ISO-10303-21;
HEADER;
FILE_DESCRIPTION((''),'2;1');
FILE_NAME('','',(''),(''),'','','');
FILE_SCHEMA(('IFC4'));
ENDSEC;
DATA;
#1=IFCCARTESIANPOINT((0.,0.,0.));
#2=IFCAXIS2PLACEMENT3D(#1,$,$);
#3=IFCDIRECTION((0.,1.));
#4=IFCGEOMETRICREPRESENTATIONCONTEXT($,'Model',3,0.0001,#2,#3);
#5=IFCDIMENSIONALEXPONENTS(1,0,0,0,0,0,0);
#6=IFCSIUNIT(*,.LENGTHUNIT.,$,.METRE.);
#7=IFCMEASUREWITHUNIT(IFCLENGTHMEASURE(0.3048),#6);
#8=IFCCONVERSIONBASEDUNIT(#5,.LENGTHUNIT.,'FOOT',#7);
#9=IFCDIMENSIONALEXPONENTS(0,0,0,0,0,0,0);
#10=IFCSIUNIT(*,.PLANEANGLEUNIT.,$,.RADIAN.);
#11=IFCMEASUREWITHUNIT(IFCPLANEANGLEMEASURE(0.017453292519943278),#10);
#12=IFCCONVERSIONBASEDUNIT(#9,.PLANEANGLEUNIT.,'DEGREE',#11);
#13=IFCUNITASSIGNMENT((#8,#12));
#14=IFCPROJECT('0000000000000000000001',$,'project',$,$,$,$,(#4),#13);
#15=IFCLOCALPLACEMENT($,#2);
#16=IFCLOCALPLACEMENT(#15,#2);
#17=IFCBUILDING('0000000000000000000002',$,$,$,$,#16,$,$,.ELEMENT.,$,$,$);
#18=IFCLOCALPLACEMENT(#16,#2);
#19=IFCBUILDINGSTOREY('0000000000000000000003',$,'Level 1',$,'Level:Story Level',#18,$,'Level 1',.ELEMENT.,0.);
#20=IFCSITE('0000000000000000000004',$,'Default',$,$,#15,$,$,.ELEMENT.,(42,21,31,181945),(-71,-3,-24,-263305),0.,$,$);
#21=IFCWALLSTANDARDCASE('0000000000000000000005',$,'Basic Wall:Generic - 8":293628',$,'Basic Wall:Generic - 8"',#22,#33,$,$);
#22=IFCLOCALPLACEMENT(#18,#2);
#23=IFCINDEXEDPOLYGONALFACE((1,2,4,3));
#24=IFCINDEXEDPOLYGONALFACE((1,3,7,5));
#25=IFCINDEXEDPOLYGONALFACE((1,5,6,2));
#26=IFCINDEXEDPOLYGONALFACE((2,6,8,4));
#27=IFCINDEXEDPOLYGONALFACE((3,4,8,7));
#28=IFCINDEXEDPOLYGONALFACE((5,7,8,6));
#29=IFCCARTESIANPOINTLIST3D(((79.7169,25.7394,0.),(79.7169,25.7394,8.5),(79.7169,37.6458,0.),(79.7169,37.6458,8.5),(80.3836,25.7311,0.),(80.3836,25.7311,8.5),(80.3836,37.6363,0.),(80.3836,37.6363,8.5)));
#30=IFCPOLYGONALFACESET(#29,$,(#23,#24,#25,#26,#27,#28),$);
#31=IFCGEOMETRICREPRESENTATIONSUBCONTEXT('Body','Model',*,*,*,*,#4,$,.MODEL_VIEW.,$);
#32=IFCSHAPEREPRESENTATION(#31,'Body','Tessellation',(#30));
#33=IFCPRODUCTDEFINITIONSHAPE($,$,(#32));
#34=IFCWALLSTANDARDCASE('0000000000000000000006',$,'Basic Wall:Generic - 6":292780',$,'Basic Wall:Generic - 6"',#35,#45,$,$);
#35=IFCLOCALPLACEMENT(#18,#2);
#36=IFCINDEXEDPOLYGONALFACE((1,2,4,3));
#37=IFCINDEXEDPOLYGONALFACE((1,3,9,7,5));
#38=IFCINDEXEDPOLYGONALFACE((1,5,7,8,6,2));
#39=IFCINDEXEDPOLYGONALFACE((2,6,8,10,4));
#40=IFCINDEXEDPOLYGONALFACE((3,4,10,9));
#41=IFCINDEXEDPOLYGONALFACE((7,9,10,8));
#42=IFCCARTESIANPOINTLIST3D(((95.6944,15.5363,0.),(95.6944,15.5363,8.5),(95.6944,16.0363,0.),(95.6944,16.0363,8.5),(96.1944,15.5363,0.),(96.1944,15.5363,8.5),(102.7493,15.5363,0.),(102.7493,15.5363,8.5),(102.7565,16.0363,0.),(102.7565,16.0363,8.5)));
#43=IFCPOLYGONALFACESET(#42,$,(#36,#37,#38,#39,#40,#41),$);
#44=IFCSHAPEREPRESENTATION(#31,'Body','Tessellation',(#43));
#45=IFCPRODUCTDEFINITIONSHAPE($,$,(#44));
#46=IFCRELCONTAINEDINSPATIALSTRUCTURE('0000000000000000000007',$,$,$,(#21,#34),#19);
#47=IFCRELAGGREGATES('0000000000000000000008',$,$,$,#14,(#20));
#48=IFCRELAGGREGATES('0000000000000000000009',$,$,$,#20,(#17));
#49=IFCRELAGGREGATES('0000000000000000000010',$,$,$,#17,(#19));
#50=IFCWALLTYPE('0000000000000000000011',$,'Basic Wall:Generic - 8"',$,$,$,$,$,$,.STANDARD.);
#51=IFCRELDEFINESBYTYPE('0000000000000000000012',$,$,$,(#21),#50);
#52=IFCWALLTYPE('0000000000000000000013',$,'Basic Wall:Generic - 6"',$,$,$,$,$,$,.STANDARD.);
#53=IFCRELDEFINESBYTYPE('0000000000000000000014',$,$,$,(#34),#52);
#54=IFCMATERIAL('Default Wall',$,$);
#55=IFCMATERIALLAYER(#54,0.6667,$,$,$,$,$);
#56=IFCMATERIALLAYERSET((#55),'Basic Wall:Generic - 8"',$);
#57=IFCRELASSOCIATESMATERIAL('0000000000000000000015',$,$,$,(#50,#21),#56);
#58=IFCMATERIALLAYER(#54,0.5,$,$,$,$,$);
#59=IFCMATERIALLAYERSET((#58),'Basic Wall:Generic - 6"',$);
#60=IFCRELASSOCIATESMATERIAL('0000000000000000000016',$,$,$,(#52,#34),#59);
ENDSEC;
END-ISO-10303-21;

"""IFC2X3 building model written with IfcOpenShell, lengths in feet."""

from ifc_helpers import new_model, entity, si_unit, converted_unit, direction, frame, origin, place, context, subcontext, project, spatial, polyline, outline, extrude, material, layer, layer_set, layer_usage, type_object, element, save


model = new_model("IFC2X3")

# Units and contexts
model_context = context("Model", 3, precision=0.0001, world=origin(), true_north=direction((0.0, 1.0)))
body_context = subcontext(model_context, "Body", "Model", "MODEL_VIEW")
ifc_project = project(units=[converted_unit("LENGTHUNIT", "FOOT", entity("IfcLengthMeasure", 0.3048), si_unit("LENGTHUNIT", "METRE"), dimensions=[1, 0, 0, 0, 0, 0, 0]), converted_unit("PLANEANGLEUNIT", "DEGREE", entity("IfcPlaneAngleMeasure", 0.017453292519943278), si_unit("PLANEANGLEUNIT", "RADIAN"), dimensions=[0, 0, 0, 0, 0, 0, 0])], contexts=[model_context])

# Site, building, storey
site_placement = place(None, origin())
site = spatial("IfcSite", under=ifc_project, at=site_placement, Name="Default", CompositionType="ELEMENT", RefLatitude=(42, 21, 31, 181945), RefLongitude=(-71, -3, -24, -263305), RefElevation=0.0)
building_placement = place(site_placement, origin())
building = spatial("IfcBuilding", under=site, at=building_placement, CompositionType="ELEMENT")
storey_placement = place(building_placement, origin())
storey = spatial("IfcBuildingStorey", under=building, at=storey_placement, Name="Level 1", ObjectType="Level:Story Level", LongName="Level 1", CompositionType="ELEMENT", Elevation=0.0)

# Walls
ifc_material = material(Name="Default Wall")
ifc_layer_1 = layer(ifc_material, 0.6667)
ifc_layer_set_1 = layer_set([ifc_layer_1], Name="Basic Wall:Generic - 8\"")
ifc_layer_usage_1 = layer_usage(ifc_layer_set_1, "AXIS2", "NEGATIVE", 0.3333)
wall_type_1 = type_object("IfcWallType", Name="Basic Wall:Generic - 8\"", PredefinedType="STANDARD", material=ifc_layer_set_1)
wall_1_placement = place(storey_placement, frame((80.0502, 37.6458, 0.0), z_axis=(0.0, 0.0, 1.0), x_axis=(0.0, -1.0, 0.0)))
element("IfcWallStandardCase", 1, at=wall_1_placement, inside=storey, type_object=wall_type_1, material=ifc_layer_usage_1, Name="Basic Wall:Generic - 8\":293628", ObjectType="Basic Wall:Generic - 8\"", context=body_context, shape_type="SweptSolid", body=[
    extrude(outline(polyline([(11.9065, -0.3333), (11.9147, 0.3333), (0.0095, 0.3333), (0.0, -0.3333), (11.9065, -0.3333)])), origin(), (0.0, 0.0, 1.0), 8.5),
])
ifc_layer_2 = layer(ifc_material, 0.5)
ifc_layer_set_2 = layer_set([ifc_layer_2], Name="Basic Wall:Generic - 6\"")
ifc_layer_usage_2 = layer_usage(ifc_layer_set_2, "AXIS2", "NEGATIVE", 0.25)
wall_type_2 = type_object("IfcWallType", Name="Basic Wall:Generic - 6\"", PredefinedType="STANDARD", material=ifc_layer_set_2)
wall_2_placement = place(storey_placement, frame((102.7565, 15.7863, 0.0), z_axis=(0.0, 0.0, 1.0), x_axis=(-1.0, 0.0, 0.0)))
element("IfcWallStandardCase", 2, at=wall_2_placement, inside=storey, type_object=wall_type_2, material=ifc_layer_usage_2, Name="Basic Wall:Generic - 6\":292780", ObjectType="Basic Wall:Generic - 6\"", context=body_context, shape_type="SweptSolid", body=[
    extrude(outline(polyline([(7.0621, -0.25), (7.0621, 0.25), (6.5621, 0.25), (0.0071, 0.25), (0.0, -0.25), (7.0621, -0.25)])), origin(), (0.0, 0.0, 1.0), 8.5),
])

save(model, "model.ifc")
